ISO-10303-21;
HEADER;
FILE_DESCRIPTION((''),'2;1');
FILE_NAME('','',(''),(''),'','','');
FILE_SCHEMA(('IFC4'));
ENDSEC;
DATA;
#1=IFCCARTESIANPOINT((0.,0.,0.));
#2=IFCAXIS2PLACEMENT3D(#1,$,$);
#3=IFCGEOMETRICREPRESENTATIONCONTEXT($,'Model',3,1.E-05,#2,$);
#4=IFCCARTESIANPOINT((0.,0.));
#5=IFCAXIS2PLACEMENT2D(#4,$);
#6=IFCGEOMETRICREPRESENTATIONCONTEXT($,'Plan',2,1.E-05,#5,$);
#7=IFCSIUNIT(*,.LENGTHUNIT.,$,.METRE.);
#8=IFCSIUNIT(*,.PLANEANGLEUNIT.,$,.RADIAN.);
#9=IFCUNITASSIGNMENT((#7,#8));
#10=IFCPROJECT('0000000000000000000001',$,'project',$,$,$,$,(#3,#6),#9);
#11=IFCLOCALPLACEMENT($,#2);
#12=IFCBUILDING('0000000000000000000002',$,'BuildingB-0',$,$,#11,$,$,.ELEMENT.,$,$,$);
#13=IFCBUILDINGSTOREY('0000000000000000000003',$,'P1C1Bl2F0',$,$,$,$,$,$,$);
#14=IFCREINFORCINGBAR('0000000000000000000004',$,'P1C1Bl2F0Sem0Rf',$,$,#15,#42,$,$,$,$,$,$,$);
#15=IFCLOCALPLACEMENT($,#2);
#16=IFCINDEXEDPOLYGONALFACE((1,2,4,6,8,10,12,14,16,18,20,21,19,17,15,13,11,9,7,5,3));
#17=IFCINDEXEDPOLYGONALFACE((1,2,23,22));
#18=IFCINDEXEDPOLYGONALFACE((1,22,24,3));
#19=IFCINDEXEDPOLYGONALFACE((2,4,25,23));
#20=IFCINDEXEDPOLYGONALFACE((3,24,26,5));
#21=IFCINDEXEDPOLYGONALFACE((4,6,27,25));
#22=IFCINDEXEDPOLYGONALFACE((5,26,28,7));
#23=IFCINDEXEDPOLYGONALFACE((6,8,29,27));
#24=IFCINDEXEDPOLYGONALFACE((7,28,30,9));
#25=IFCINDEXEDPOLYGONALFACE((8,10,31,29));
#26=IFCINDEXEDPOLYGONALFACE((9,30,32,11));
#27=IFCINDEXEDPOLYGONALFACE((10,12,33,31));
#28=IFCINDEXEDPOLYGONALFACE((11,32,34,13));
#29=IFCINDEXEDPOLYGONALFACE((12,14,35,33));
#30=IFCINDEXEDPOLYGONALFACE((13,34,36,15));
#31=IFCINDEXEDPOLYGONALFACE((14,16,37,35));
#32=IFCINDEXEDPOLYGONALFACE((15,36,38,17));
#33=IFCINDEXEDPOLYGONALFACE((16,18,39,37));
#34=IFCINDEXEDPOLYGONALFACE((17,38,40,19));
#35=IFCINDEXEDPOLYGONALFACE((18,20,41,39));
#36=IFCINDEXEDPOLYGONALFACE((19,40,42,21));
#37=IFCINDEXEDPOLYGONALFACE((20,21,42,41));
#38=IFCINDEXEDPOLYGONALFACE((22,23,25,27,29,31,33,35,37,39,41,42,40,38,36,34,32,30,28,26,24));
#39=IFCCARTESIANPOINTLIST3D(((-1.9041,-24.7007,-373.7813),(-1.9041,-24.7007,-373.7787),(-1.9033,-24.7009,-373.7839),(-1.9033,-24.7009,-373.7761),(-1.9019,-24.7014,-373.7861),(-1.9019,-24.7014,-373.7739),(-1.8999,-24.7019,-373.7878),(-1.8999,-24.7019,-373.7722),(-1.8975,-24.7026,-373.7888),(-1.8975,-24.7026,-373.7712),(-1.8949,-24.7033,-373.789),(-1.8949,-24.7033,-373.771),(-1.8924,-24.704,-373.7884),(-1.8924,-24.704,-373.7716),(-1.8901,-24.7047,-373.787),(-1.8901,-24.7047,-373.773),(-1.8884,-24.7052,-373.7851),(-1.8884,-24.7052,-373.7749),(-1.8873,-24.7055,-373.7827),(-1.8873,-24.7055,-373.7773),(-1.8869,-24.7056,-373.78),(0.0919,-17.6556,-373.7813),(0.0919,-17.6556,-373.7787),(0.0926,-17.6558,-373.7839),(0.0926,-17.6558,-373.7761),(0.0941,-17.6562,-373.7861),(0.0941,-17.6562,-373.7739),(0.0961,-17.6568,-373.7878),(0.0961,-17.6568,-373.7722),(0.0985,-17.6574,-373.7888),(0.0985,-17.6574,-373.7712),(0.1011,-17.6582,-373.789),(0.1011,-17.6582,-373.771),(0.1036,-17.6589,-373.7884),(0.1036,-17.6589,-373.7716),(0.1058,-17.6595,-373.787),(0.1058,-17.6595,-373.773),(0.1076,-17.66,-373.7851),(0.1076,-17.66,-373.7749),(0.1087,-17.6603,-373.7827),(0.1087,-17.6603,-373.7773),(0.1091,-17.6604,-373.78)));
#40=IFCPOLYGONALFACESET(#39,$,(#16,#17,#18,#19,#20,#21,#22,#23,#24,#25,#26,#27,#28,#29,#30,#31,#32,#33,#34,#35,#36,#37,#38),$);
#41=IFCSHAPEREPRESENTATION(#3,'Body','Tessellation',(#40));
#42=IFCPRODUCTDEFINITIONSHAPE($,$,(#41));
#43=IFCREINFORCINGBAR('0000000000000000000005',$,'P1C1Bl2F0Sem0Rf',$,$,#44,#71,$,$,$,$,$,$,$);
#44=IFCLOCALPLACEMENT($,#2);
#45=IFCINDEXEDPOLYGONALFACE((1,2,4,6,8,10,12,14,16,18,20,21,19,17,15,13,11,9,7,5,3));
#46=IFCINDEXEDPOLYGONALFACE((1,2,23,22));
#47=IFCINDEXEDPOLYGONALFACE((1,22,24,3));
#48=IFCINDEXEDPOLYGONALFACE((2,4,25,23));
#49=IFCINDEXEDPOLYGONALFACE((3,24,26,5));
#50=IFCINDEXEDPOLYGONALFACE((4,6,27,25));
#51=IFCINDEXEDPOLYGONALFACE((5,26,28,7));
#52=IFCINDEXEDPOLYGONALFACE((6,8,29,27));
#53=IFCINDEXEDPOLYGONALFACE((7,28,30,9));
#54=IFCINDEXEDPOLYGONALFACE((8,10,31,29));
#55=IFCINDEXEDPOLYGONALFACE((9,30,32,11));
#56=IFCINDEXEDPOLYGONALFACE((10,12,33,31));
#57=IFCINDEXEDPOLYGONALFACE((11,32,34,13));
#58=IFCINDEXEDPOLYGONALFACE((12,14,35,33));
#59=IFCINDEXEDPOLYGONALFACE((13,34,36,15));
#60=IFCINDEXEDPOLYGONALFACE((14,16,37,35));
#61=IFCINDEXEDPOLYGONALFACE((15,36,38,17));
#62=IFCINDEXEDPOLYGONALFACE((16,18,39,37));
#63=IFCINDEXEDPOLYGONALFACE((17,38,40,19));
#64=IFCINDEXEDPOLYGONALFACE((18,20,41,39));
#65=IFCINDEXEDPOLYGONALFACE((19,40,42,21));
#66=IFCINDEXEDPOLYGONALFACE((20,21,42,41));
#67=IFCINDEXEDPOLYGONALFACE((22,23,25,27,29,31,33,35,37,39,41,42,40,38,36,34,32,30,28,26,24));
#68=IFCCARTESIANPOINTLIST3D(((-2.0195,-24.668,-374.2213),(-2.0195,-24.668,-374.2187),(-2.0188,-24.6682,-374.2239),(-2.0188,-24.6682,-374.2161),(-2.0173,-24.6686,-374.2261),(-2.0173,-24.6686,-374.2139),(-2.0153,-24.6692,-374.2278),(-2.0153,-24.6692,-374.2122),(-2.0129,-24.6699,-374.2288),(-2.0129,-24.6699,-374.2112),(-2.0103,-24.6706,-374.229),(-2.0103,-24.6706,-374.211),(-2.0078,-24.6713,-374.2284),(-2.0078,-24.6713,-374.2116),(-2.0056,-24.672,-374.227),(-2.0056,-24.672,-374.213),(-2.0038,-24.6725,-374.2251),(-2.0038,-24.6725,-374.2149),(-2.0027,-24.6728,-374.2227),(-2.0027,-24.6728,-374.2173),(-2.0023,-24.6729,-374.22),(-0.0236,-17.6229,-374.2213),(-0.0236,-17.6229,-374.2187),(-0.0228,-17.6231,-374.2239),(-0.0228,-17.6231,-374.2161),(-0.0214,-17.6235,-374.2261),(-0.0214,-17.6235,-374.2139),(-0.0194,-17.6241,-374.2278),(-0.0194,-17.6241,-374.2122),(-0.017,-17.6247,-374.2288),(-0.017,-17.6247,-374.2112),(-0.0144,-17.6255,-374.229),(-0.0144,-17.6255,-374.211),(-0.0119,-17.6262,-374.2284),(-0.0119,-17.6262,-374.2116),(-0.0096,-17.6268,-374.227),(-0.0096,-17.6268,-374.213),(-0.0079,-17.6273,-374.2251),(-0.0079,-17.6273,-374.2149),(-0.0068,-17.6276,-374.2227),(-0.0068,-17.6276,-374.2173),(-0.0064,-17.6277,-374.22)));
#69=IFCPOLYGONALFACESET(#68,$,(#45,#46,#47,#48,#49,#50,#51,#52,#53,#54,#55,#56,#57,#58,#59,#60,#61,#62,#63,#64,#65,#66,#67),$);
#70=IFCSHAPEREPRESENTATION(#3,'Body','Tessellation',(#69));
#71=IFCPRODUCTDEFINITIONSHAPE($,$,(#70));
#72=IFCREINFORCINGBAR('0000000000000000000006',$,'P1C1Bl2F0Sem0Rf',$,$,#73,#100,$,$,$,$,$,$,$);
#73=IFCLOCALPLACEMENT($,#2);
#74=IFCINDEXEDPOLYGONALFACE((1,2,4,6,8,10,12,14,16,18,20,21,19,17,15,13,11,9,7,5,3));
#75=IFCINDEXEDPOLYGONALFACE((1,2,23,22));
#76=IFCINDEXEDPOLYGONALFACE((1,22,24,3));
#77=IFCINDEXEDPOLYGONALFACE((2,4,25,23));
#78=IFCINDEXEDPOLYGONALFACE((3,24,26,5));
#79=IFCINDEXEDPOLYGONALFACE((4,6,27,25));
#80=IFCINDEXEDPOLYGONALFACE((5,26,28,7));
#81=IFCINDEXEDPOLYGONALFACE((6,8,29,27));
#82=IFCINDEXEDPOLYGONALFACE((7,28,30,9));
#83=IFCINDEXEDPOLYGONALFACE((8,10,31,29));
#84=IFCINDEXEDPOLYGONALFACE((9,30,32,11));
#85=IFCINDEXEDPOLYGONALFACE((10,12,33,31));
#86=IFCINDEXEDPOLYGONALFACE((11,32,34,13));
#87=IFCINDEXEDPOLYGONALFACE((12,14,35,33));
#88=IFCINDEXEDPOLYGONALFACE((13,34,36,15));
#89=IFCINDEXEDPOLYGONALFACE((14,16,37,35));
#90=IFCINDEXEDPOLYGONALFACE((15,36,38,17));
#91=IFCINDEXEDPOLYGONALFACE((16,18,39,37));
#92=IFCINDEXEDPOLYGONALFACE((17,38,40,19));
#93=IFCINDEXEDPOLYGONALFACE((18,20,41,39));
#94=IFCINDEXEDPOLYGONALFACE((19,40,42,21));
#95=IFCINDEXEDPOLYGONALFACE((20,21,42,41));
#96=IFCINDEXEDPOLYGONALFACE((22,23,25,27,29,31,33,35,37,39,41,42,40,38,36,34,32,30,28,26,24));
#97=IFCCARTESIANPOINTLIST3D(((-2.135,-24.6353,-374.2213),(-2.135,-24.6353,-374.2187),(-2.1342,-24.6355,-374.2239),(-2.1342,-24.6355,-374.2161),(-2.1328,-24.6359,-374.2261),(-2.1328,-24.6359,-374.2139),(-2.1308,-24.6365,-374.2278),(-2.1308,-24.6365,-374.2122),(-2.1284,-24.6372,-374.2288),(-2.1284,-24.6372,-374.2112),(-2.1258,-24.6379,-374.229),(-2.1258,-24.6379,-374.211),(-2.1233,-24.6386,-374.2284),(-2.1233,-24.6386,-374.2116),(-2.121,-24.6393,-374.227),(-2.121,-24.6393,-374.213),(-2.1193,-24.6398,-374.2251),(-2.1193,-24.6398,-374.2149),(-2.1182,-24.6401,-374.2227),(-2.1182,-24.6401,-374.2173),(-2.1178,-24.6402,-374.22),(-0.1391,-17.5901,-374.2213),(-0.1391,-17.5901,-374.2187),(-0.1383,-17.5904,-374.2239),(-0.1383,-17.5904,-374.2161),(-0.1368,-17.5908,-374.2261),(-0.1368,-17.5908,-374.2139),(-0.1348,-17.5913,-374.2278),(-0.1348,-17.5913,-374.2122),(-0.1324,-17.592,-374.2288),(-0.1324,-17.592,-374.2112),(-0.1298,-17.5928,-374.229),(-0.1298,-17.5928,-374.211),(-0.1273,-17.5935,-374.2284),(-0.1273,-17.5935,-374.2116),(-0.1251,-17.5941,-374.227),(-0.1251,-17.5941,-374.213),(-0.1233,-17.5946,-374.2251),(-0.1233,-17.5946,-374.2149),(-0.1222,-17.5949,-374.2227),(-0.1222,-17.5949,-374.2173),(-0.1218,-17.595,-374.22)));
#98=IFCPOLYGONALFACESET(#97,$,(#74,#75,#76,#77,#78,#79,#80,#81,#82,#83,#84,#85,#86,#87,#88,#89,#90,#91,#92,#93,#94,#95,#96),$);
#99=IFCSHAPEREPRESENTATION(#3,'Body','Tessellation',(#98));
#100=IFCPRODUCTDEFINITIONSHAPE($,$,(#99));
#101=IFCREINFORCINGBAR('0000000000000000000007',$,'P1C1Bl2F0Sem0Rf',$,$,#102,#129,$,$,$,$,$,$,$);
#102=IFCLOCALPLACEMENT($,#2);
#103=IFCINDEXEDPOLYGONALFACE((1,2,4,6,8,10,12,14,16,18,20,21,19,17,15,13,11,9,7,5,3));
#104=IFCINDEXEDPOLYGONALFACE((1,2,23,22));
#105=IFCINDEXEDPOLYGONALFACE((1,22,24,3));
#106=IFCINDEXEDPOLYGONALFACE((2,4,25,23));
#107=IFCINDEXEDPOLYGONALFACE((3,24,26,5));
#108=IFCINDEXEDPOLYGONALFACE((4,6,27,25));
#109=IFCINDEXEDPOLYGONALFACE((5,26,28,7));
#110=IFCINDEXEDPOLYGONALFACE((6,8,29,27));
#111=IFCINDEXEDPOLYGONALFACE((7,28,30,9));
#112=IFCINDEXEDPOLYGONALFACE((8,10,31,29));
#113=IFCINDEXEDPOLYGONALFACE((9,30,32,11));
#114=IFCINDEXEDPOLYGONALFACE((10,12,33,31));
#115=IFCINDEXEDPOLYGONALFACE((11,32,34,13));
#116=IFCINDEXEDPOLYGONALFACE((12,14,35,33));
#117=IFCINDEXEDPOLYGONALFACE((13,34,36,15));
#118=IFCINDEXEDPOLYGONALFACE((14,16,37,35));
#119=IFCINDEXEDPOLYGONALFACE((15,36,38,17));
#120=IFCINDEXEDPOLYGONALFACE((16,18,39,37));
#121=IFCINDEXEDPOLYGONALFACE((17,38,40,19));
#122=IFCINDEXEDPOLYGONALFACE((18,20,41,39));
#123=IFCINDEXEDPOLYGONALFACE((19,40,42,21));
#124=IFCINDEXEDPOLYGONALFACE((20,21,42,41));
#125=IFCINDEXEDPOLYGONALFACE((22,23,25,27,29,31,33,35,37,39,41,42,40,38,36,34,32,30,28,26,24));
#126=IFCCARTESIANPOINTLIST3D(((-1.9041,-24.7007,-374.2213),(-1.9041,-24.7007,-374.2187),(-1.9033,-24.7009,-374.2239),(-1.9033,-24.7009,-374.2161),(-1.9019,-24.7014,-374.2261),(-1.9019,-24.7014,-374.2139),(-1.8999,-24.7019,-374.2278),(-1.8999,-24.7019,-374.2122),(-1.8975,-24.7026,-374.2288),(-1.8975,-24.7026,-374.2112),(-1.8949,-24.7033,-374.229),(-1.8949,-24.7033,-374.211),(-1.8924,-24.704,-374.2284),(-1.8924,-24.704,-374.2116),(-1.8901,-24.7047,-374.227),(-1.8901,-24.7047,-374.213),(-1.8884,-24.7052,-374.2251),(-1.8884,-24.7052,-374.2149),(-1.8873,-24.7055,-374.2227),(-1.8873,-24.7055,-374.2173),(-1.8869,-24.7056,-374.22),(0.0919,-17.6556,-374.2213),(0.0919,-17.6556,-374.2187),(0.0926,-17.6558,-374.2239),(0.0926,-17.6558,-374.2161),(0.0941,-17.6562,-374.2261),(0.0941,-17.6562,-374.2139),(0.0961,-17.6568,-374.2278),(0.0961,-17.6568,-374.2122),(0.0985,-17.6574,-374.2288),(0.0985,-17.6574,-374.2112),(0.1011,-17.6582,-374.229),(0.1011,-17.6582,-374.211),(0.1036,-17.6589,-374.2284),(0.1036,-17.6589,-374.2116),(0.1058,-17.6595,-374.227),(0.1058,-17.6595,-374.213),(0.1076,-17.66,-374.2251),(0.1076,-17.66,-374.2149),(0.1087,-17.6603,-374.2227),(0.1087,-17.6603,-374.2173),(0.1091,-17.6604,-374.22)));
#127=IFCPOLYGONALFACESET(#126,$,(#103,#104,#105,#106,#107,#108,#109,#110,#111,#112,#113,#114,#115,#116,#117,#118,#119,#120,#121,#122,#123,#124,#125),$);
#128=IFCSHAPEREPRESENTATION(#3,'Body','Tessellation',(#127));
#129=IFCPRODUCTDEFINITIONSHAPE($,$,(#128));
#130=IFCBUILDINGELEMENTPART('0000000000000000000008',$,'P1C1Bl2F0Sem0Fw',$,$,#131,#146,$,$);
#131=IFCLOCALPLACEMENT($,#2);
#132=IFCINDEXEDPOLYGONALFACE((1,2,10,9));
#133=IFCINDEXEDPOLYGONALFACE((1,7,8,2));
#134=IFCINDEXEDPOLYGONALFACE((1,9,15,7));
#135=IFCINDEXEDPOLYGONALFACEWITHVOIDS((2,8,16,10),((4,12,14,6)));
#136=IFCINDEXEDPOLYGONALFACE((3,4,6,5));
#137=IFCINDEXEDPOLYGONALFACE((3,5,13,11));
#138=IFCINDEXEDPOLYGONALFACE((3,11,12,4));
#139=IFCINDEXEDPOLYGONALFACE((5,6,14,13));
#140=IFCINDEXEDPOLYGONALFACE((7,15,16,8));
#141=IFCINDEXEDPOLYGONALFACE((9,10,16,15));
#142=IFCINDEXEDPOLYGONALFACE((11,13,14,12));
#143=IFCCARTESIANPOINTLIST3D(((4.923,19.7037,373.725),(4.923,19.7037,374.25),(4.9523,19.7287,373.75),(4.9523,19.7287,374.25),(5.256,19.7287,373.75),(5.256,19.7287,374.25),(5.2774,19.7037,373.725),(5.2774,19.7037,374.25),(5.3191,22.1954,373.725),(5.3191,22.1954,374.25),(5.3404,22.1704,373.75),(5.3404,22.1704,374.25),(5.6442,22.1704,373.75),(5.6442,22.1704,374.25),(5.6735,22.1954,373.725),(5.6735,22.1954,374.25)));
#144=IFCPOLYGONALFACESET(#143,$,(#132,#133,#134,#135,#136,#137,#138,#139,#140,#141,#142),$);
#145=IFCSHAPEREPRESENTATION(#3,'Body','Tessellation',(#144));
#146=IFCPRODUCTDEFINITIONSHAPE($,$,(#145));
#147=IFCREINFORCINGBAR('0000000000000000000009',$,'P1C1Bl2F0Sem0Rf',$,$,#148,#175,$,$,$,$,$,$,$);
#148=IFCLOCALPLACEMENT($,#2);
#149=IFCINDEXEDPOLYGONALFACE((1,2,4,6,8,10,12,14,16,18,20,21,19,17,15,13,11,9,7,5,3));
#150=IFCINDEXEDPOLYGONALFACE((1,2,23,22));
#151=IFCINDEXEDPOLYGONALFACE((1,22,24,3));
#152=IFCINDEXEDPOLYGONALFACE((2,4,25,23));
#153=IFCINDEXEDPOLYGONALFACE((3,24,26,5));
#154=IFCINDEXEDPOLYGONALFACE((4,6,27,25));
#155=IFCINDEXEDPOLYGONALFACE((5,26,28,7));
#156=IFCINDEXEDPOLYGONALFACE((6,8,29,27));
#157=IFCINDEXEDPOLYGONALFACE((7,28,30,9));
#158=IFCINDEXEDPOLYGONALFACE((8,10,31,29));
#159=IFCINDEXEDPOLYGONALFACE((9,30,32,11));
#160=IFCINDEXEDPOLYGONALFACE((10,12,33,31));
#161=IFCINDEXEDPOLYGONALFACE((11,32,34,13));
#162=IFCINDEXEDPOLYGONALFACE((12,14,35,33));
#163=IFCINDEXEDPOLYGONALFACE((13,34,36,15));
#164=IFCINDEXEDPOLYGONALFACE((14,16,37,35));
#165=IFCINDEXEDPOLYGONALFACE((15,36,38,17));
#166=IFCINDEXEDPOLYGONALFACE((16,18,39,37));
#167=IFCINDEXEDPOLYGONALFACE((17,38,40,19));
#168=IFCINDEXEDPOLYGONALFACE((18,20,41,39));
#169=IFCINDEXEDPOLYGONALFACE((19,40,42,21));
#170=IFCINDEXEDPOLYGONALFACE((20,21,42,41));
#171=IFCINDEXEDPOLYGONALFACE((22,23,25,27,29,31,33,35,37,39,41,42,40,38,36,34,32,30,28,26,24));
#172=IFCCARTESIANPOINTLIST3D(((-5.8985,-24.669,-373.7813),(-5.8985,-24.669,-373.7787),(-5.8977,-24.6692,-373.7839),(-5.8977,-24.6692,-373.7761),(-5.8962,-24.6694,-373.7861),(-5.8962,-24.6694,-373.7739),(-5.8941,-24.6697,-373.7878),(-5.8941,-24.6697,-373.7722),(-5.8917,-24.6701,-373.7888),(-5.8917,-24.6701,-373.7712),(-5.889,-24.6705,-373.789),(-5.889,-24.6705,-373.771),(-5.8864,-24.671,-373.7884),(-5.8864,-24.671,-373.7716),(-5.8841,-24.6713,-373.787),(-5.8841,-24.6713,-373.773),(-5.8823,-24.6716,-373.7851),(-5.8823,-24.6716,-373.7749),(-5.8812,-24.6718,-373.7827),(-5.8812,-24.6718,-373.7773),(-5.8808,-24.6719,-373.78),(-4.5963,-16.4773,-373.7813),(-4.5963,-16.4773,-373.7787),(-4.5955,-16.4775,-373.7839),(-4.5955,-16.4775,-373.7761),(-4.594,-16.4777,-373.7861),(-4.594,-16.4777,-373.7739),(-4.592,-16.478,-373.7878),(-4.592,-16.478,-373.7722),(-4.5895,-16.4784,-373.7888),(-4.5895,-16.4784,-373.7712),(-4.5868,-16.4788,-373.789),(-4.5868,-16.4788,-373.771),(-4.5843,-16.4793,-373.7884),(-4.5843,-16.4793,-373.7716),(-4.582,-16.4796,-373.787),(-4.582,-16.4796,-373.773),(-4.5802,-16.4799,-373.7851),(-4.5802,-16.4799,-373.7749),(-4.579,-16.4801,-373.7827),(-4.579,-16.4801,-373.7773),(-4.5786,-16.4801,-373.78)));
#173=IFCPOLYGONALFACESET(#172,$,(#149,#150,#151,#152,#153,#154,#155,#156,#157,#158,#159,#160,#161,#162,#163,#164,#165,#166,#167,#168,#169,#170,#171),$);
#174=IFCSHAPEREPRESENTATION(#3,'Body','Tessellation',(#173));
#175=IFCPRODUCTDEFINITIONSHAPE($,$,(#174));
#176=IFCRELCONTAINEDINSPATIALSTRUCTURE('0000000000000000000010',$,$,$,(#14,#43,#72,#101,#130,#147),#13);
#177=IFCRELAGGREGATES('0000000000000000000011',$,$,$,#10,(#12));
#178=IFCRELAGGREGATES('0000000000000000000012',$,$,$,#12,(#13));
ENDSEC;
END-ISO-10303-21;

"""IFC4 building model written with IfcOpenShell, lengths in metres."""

from ifc_helpers import new_model, entity, si_unit, origin, origin_2d, place, context, project, spatial, polyline, outline, extrude, element, save


model = new_model("IFC4")

# Units and contexts
model_context = context("Model", 3, precision=1e-05, world=origin())
plan_context = context("Plan", 2, precision=1e-05, world=origin_2d())
ifc_project = project(units=[si_unit("LENGTHUNIT", "METRE"), si_unit("PLANEANGLEUNIT", "RADIAN")], contexts=[model_context, plan_context])

# Building, storey
building_placement = place(None, origin())
building = spatial("IfcBuilding", under=ifc_project, at=building_placement, Name="BuildingB-0", CompositionType="ELEMENT")
storey = spatial("IfcBuildingStorey", under=building, Name="P1C1Bl2F0")

# Reinforcing bars
element("IfcReinforcingBar", 1, inside=storey, Name="P1C1Bl2F0Sem0Rf", context=model_context, shape_type="SweptSolid", body=[
    entity("IfcSurfaceCurveSweptAreaSolid", entity("IfcCircleProfileDef", "AREA", None, None, 0.009), None, entity("IfcPolyline", [entity("IfcCartesianPoint", [-0.1004, 17.658, 373.78]), entity("IfcCartesianPoint", [1.8955, 24.7032, 373.78])]), None, None, entity("IfcPlane", entity("IfcAxis2Placement3D", entity("IfcCartesianPoint", [-0.1004, 17.658, 373.78]), entity("IfcDirection", [0.0, 0.0, 1.0]), entity("IfcDirection", [1.0, 0.0, 0.0])))),
])
element("IfcReinforcingBar", 2, inside=storey, Name="P1C1Bl2F0Sem0Rf", context=model_context, shape_type="SweptSolid", body=[
    entity("IfcSurfaceCurveSweptAreaSolid", entity("IfcCircleProfileDef", "AREA", None, None, 0.009), None, entity("IfcPolyline", [entity("IfcCartesianPoint", [0.015, 17.6253, 374.22]), entity("IfcCartesianPoint", [2.011, 24.6704, 374.22])]), None, None, entity("IfcPlane", entity("IfcAxis2Placement3D", entity("IfcCartesianPoint", [0.015, 17.6253, 374.22]), entity("IfcDirection", [0.0, 0.0, 1.0]), entity("IfcDirection", [1.0, 0.0, 0.0])))),
])
element("IfcReinforcingBar", 3, inside=storey, Name="P1C1Bl2F0Sem0Rf", context=model_context, shape_type="SweptSolid", body=[
    entity("IfcSurfaceCurveSweptAreaSolid", entity("IfcCircleProfileDef", "AREA", None, None, 0.009), None, entity("IfcPolyline", [entity("IfcCartesianPoint", [0.1305, 17.5926, 374.22]), entity("IfcCartesianPoint", [2.1264, 24.6377, 374.22])]), None, None, entity("IfcPlane", entity("IfcAxis2Placement3D", entity("IfcCartesianPoint", [0.1305, 17.5926, 374.22]), entity("IfcDirection", [0.0, 0.0, 1.0]), entity("IfcDirection", [1.0, 0.0, 0.0])))),
])
element("IfcReinforcingBar", 4, inside=storey, Name="P1C1Bl2F0Sem0Rf", context=model_context, shape_type="SweptSolid", body=[
    entity("IfcSurfaceCurveSweptAreaSolid", entity("IfcCircleProfileDef", "AREA", None, None, 0.009), None, entity("IfcPolyline", [entity("IfcCartesianPoint", [-0.1004, 17.658, 374.22]), entity("IfcCartesianPoint", [1.8955, 24.7032, 374.22])]), None, None, entity("IfcPlane", entity("IfcAxis2Placement3D", entity("IfcCartesianPoint", [-0.1004, 17.658, 374.22]), entity("IfcDirection", [0.0, 0.0, 1.0]), entity("IfcDirection", [1.0, 0.0, 0.0])))),
])

# Building element part, opening
building_element_part_1 = element("IfcBuildingElementPart", 5, inside=storey, Name="P1C1Bl2F0Sem0Fw", context=model_context, shape_type="SweptSolid", body=[
    extrude(outline(polyline([(5.2774, 19.7037, 373.725), (4.923, 19.7037, 373.725), (5.3191, 22.1954, 373.725), (5.6735, 22.1954, 373.725), (5.2774, 19.7037, 373.725)])), None, (0.0, 0.0, 1.0), 0.525),
])
element("IfcOpeningElement", 6, inside=storey, cuts=building_element_part_1, context=model_context, shape_type="SweptSolid", body=[
    extrude(outline(polyline([(5.256, 19.7287, 373.75), (4.9523, 19.7287, 373.75), (5.3404, 22.1704, 373.75), (5.6442, 22.1704, 373.75), (5.256, 19.7287, 373.75)])), None, (0.0, 0.0, 1.0), 0.5),
])

# Reinforcing bar
element("IfcReinforcingBar", 7, inside=storey, Name="P1C1Bl2F0Sem0Rf", context=model_context, shape_type="SweptSolid", body=[
    entity("IfcSurfaceCurveSweptAreaSolid", entity("IfcCircleProfileDef", "AREA", None, None, 0.009), None, entity("IfcPolyline", [entity("IfcCartesianPoint", [4.5875, 16.4787, 373.78]), entity("IfcCartesianPoint", [5.8897, 24.6704, 373.78])]), None, None, entity("IfcPlane", entity("IfcAxis2Placement3D", entity("IfcCartesianPoint", [4.5875, 16.4787, 373.78]), entity("IfcDirection", [0.0, 0.0, 1.0]), entity("IfcDirection", [1.0, 0.0, 0.0])))),
])

save(model, "model.ifc")
